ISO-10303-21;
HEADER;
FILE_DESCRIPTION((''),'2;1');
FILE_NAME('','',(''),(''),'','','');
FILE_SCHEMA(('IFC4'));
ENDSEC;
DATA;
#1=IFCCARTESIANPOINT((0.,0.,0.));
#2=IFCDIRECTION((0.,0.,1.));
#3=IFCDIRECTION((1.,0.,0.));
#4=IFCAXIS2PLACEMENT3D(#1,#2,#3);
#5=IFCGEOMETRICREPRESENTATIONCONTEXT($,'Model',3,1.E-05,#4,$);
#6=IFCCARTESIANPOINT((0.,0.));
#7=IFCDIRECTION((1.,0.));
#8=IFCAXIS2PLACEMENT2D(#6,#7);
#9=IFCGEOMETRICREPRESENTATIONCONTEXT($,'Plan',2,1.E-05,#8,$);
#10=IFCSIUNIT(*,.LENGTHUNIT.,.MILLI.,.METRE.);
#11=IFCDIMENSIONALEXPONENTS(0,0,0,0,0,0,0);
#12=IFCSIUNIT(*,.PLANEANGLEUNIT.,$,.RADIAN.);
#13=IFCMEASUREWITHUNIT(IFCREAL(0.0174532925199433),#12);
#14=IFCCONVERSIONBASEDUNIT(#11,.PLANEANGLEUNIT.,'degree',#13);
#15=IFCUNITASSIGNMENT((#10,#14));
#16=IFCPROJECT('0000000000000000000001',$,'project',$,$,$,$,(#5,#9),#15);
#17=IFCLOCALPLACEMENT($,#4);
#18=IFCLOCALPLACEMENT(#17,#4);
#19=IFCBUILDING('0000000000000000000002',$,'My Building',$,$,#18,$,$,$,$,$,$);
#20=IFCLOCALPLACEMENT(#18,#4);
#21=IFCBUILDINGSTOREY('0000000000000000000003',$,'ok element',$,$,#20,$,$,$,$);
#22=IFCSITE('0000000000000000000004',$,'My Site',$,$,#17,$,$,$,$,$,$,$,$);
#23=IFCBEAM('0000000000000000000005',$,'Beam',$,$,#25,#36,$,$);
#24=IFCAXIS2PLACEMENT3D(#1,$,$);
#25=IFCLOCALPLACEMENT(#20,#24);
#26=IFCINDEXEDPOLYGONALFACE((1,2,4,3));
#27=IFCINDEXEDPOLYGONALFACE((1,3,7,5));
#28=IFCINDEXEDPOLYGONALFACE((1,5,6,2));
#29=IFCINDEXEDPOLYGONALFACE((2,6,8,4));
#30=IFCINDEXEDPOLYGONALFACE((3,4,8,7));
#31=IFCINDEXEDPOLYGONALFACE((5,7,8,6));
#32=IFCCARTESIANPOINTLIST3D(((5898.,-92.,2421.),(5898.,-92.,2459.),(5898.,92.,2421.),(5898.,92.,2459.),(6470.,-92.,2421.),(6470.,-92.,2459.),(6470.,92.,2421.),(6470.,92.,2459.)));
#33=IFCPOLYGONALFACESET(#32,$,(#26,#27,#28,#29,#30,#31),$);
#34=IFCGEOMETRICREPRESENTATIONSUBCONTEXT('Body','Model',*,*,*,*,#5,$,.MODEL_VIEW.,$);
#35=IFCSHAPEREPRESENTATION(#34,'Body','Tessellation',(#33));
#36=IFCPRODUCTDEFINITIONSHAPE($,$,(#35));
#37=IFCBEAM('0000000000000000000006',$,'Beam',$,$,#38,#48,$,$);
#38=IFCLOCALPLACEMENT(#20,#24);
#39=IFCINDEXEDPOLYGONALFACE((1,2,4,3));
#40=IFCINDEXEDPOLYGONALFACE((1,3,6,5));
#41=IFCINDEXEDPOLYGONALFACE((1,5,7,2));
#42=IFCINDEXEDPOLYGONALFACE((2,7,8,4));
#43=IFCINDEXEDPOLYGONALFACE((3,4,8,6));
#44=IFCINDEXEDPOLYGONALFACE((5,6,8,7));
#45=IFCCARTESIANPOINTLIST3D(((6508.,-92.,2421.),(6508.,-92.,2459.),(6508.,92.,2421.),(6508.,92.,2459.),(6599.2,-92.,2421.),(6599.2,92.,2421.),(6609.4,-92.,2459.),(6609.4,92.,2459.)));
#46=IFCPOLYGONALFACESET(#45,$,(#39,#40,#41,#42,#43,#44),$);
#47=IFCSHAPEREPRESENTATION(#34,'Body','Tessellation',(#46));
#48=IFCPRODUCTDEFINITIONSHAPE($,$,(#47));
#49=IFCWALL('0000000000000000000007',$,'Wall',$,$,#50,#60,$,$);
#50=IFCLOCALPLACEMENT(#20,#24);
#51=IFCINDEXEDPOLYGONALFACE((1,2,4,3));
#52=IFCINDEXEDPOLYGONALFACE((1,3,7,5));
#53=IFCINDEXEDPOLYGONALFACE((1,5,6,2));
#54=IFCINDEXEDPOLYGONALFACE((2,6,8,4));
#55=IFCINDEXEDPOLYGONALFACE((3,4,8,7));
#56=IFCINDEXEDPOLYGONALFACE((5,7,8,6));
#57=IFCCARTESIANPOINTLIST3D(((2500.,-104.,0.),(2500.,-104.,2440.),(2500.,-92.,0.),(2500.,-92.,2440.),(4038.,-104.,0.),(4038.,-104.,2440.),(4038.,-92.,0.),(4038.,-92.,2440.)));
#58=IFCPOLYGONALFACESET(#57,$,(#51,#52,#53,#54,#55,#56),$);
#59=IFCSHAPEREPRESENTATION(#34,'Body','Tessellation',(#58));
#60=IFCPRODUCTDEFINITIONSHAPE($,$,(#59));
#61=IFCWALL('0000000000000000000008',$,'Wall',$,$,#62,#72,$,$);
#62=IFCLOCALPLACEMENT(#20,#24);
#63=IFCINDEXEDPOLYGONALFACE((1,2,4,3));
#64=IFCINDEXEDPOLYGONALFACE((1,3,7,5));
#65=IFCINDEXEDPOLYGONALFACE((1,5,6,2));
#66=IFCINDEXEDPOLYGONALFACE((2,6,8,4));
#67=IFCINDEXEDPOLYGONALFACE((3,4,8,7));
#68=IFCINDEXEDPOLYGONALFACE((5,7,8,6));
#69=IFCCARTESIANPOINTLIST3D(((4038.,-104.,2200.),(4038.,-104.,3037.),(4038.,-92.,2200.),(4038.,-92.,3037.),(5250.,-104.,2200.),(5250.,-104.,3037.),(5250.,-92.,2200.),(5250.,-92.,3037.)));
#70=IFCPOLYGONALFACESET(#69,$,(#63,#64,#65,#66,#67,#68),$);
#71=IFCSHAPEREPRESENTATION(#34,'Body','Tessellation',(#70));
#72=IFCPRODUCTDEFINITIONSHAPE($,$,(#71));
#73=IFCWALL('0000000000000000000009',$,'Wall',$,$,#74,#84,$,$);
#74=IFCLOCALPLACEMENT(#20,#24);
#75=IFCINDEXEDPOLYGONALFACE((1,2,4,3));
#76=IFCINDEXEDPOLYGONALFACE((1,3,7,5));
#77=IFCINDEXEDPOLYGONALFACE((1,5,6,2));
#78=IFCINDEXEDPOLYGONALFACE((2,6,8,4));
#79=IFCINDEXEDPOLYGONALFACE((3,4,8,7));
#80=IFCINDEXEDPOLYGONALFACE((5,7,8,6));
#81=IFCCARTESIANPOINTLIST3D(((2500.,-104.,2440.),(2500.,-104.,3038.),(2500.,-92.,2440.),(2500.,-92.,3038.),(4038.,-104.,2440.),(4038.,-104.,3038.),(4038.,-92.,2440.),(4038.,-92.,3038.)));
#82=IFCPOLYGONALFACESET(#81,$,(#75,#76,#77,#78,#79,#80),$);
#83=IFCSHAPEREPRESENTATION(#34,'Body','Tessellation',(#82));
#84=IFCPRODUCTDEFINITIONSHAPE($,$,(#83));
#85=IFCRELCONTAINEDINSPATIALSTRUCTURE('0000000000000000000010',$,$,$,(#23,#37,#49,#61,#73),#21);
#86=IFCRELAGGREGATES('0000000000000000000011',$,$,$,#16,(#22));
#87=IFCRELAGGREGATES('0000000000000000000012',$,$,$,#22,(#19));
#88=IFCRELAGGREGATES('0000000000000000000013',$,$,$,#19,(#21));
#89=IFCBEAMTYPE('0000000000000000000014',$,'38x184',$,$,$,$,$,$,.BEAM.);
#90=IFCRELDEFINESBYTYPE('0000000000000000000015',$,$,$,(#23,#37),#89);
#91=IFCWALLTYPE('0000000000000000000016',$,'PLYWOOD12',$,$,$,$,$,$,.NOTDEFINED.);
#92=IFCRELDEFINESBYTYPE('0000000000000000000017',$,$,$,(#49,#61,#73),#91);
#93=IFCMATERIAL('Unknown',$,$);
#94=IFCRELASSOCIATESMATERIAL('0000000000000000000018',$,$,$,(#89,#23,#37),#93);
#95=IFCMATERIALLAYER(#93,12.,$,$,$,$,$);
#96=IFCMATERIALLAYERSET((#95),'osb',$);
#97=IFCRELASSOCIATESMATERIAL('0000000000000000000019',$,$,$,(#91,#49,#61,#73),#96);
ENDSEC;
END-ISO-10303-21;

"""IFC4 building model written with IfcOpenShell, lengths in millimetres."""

from ifc_helpers import new_model, entity, si_unit, converted_unit, frame, origin_with_axes, origin_2d_with_axis, place, context, subcontext, project, spatial, indexed_curve, rectangle, outline, extrude, clip, halfspace, material, layer, layer_set, layer_usage, material_profile, profile_set, profile_usage, type_object, element, save


model = new_model("IFC4")

# Units and contexts
model_context = context("Model", 3, precision=1e-05, world=origin_with_axes())
plan_context = context("Plan", 2, precision=1e-05, world=origin_2d_with_axis())
body_context = subcontext(model_context, "Body", "Model", "MODEL_VIEW")
ifc_project = project(units=[si_unit("LENGTHUNIT", "METRE", prefix="MILLI"), converted_unit("PLANEANGLEUNIT", "degree", entity("IfcReal", 0.0174532925199433), si_unit("PLANEANGLEUNIT", "RADIAN"), dimensions=[0, 0, 0, 0, 0, 0, 0])], contexts=[model_context, plan_context])

# Site, building, storey
site_placement = place(None, origin_with_axes())
site = spatial("IfcSite", under=ifc_project, at=site_placement, Name="My Site")
building_placement = place(site_placement, origin_with_axes())
building = spatial("IfcBuilding", under=site, at=building_placement, Name="My Building")
storey_placement = place(building_placement, origin_with_axes())
storey = spatial("IfcBuildingStorey", under=building, at=storey_placement, Name="ok element")

# Beams
ifc_material = material(Name="Unknown")
ifc_material_profile = material_profile(ifc_material, rectangle(XDim=184.0, YDim=38.0))
ifc_profile_set = profile_set([ifc_material_profile], Name="vurenhout")
beam_type = type_object("IfcBeamType", Name="38x184", PredefinedType="BEAM", material=ifc_profile_set)
ifc_profile_usage_1 = profile_usage(ifc_profile_set, cardinal=2)
beam_1_placement = place(storey_placement, frame((5898.0, 0.0, 2421.0), z_axis=(1.0, 0.0, 0.0), x_axis=(0.0, 1.0, 0.0)))
element("IfcBeam", 1, at=beam_1_placement, inside=storey, type_object=beam_type, material=ifc_profile_usage_1, Name="Beam", context=body_context, shape_type="SweptSolid", body=[
    extrude(rectangle(XDim=184.0, YDim=38.0), frame((0.0, 19.0, 0.0), z_axis=(0.0, 0.0, 1.0), x_axis=(1.0, 0.0, 0.0)), (0.0, 0.0, 1.0), 572.0),
])
ifc_profile_usage_2 = profile_usage(ifc_profile_set, cardinal=2)
beam_2_placement = place(storey_placement, frame((6508.0, 0.0, 2421.0), z_axis=(1.0, 0.0, 0.0), x_axis=(0.0, 1.0, 0.0)))
element("IfcBeam", 2, at=beam_2_placement, inside=storey, type_object=beam_type, material=ifc_profile_usage_2, Name="Beam", context=body_context, shape_type="Clipping", body=[
    clip(extrude(rectangle(XDim=184.0, YDim=38.0), frame((0.0, 19.0, 0.0), z_axis=(0.0, 0.0, 1.0), x_axis=(1.0, 0.0, 0.0)), (0.0, 0.0, 1.0), 275.2), halfspace(frame((0.0, -2550.9, -592.3), z_axis=(0.0, -0.258819, 0.965926), x_axis=(0.0, 0.965926, 0.258819)), False)),
])

# Walls
ifc_layer = layer(ifc_material, 12.0)
ifc_layer_set = layer_set([ifc_layer], Name="osb")
ifc_layer_usage_1 = layer_usage(ifc_layer_set, "AXIS2", "POSITIVE", 0.0)
wall_type = type_object("IfcWallType", Name="PLYWOOD12", PredefinedType="NOTDEFINED", material=ifc_layer_set)
wall_1_placement = place(storey_placement, frame((2500.0, -104.0, 0.0), z_axis=(0.0, 0.0, 1.0), x_axis=(1.0, 0.0, 0.0)))
element("IfcWall", 3, at=wall_1_placement, inside=storey, type_object=wall_type, material=ifc_layer_usage_1, Name="Wall", context=body_context, shape_type="SweptSolid", body=[
    extrude(outline(indexed_curve([(0.0, 0.0), (0.0, 12.0), (1538.0, 12.0), (1538.0, 0.0), (0.0, 0.0)], self_intersect=False)), origin_with_axes(), (0.0, 0.0, 1.0), 2440.0),
])
ifc_layer_usage_2 = layer_usage(ifc_layer_set, "AXIS2", "POSITIVE", 0.0)
wall_2_placement = place(storey_placement, frame((4038.0, -104.0, 2200.0), z_axis=(0.0, 0.0, 1.0), x_axis=(1.0, 0.0, 0.0)))
element("IfcWall", 4, at=wall_2_placement, inside=storey, type_object=wall_type, material=ifc_layer_usage_2, Name="Wall", context=body_context, shape_type="SweptSolid", body=[
    extrude(outline(indexed_curve([(0.0, 0.0), (0.0, 12.0), (1212.0, 12.0), (1212.0, 0.0), (0.0, 0.0)], self_intersect=False)), origin_with_axes(), (0.0, 0.0, 1.0), 837.0),
])
ifc_layer_usage_3 = layer_usage(ifc_layer_set, "AXIS2", "POSITIVE", 0.0)
wall_3_placement = place(storey_placement, frame((2500.0, -104.0, 2440.0), z_axis=(0.0, 0.0, 1.0), x_axis=(1.0, 0.0, 0.0)))
element("IfcWall", 5, at=wall_3_placement, inside=storey, type_object=wall_type, material=ifc_layer_usage_3, Name="Wall", context=body_context, shape_type="SweptSolid", body=[
    extrude(outline(indexed_curve([(0.0, 0.0), (0.0, 12.0), (1538.0, 12.0), (1538.0, 0.0), (0.0, 0.0)], self_intersect=False)), origin_with_axes(), (0.0, 0.0, 1.0), 598.0),
])

save(model, "model.ifc")
